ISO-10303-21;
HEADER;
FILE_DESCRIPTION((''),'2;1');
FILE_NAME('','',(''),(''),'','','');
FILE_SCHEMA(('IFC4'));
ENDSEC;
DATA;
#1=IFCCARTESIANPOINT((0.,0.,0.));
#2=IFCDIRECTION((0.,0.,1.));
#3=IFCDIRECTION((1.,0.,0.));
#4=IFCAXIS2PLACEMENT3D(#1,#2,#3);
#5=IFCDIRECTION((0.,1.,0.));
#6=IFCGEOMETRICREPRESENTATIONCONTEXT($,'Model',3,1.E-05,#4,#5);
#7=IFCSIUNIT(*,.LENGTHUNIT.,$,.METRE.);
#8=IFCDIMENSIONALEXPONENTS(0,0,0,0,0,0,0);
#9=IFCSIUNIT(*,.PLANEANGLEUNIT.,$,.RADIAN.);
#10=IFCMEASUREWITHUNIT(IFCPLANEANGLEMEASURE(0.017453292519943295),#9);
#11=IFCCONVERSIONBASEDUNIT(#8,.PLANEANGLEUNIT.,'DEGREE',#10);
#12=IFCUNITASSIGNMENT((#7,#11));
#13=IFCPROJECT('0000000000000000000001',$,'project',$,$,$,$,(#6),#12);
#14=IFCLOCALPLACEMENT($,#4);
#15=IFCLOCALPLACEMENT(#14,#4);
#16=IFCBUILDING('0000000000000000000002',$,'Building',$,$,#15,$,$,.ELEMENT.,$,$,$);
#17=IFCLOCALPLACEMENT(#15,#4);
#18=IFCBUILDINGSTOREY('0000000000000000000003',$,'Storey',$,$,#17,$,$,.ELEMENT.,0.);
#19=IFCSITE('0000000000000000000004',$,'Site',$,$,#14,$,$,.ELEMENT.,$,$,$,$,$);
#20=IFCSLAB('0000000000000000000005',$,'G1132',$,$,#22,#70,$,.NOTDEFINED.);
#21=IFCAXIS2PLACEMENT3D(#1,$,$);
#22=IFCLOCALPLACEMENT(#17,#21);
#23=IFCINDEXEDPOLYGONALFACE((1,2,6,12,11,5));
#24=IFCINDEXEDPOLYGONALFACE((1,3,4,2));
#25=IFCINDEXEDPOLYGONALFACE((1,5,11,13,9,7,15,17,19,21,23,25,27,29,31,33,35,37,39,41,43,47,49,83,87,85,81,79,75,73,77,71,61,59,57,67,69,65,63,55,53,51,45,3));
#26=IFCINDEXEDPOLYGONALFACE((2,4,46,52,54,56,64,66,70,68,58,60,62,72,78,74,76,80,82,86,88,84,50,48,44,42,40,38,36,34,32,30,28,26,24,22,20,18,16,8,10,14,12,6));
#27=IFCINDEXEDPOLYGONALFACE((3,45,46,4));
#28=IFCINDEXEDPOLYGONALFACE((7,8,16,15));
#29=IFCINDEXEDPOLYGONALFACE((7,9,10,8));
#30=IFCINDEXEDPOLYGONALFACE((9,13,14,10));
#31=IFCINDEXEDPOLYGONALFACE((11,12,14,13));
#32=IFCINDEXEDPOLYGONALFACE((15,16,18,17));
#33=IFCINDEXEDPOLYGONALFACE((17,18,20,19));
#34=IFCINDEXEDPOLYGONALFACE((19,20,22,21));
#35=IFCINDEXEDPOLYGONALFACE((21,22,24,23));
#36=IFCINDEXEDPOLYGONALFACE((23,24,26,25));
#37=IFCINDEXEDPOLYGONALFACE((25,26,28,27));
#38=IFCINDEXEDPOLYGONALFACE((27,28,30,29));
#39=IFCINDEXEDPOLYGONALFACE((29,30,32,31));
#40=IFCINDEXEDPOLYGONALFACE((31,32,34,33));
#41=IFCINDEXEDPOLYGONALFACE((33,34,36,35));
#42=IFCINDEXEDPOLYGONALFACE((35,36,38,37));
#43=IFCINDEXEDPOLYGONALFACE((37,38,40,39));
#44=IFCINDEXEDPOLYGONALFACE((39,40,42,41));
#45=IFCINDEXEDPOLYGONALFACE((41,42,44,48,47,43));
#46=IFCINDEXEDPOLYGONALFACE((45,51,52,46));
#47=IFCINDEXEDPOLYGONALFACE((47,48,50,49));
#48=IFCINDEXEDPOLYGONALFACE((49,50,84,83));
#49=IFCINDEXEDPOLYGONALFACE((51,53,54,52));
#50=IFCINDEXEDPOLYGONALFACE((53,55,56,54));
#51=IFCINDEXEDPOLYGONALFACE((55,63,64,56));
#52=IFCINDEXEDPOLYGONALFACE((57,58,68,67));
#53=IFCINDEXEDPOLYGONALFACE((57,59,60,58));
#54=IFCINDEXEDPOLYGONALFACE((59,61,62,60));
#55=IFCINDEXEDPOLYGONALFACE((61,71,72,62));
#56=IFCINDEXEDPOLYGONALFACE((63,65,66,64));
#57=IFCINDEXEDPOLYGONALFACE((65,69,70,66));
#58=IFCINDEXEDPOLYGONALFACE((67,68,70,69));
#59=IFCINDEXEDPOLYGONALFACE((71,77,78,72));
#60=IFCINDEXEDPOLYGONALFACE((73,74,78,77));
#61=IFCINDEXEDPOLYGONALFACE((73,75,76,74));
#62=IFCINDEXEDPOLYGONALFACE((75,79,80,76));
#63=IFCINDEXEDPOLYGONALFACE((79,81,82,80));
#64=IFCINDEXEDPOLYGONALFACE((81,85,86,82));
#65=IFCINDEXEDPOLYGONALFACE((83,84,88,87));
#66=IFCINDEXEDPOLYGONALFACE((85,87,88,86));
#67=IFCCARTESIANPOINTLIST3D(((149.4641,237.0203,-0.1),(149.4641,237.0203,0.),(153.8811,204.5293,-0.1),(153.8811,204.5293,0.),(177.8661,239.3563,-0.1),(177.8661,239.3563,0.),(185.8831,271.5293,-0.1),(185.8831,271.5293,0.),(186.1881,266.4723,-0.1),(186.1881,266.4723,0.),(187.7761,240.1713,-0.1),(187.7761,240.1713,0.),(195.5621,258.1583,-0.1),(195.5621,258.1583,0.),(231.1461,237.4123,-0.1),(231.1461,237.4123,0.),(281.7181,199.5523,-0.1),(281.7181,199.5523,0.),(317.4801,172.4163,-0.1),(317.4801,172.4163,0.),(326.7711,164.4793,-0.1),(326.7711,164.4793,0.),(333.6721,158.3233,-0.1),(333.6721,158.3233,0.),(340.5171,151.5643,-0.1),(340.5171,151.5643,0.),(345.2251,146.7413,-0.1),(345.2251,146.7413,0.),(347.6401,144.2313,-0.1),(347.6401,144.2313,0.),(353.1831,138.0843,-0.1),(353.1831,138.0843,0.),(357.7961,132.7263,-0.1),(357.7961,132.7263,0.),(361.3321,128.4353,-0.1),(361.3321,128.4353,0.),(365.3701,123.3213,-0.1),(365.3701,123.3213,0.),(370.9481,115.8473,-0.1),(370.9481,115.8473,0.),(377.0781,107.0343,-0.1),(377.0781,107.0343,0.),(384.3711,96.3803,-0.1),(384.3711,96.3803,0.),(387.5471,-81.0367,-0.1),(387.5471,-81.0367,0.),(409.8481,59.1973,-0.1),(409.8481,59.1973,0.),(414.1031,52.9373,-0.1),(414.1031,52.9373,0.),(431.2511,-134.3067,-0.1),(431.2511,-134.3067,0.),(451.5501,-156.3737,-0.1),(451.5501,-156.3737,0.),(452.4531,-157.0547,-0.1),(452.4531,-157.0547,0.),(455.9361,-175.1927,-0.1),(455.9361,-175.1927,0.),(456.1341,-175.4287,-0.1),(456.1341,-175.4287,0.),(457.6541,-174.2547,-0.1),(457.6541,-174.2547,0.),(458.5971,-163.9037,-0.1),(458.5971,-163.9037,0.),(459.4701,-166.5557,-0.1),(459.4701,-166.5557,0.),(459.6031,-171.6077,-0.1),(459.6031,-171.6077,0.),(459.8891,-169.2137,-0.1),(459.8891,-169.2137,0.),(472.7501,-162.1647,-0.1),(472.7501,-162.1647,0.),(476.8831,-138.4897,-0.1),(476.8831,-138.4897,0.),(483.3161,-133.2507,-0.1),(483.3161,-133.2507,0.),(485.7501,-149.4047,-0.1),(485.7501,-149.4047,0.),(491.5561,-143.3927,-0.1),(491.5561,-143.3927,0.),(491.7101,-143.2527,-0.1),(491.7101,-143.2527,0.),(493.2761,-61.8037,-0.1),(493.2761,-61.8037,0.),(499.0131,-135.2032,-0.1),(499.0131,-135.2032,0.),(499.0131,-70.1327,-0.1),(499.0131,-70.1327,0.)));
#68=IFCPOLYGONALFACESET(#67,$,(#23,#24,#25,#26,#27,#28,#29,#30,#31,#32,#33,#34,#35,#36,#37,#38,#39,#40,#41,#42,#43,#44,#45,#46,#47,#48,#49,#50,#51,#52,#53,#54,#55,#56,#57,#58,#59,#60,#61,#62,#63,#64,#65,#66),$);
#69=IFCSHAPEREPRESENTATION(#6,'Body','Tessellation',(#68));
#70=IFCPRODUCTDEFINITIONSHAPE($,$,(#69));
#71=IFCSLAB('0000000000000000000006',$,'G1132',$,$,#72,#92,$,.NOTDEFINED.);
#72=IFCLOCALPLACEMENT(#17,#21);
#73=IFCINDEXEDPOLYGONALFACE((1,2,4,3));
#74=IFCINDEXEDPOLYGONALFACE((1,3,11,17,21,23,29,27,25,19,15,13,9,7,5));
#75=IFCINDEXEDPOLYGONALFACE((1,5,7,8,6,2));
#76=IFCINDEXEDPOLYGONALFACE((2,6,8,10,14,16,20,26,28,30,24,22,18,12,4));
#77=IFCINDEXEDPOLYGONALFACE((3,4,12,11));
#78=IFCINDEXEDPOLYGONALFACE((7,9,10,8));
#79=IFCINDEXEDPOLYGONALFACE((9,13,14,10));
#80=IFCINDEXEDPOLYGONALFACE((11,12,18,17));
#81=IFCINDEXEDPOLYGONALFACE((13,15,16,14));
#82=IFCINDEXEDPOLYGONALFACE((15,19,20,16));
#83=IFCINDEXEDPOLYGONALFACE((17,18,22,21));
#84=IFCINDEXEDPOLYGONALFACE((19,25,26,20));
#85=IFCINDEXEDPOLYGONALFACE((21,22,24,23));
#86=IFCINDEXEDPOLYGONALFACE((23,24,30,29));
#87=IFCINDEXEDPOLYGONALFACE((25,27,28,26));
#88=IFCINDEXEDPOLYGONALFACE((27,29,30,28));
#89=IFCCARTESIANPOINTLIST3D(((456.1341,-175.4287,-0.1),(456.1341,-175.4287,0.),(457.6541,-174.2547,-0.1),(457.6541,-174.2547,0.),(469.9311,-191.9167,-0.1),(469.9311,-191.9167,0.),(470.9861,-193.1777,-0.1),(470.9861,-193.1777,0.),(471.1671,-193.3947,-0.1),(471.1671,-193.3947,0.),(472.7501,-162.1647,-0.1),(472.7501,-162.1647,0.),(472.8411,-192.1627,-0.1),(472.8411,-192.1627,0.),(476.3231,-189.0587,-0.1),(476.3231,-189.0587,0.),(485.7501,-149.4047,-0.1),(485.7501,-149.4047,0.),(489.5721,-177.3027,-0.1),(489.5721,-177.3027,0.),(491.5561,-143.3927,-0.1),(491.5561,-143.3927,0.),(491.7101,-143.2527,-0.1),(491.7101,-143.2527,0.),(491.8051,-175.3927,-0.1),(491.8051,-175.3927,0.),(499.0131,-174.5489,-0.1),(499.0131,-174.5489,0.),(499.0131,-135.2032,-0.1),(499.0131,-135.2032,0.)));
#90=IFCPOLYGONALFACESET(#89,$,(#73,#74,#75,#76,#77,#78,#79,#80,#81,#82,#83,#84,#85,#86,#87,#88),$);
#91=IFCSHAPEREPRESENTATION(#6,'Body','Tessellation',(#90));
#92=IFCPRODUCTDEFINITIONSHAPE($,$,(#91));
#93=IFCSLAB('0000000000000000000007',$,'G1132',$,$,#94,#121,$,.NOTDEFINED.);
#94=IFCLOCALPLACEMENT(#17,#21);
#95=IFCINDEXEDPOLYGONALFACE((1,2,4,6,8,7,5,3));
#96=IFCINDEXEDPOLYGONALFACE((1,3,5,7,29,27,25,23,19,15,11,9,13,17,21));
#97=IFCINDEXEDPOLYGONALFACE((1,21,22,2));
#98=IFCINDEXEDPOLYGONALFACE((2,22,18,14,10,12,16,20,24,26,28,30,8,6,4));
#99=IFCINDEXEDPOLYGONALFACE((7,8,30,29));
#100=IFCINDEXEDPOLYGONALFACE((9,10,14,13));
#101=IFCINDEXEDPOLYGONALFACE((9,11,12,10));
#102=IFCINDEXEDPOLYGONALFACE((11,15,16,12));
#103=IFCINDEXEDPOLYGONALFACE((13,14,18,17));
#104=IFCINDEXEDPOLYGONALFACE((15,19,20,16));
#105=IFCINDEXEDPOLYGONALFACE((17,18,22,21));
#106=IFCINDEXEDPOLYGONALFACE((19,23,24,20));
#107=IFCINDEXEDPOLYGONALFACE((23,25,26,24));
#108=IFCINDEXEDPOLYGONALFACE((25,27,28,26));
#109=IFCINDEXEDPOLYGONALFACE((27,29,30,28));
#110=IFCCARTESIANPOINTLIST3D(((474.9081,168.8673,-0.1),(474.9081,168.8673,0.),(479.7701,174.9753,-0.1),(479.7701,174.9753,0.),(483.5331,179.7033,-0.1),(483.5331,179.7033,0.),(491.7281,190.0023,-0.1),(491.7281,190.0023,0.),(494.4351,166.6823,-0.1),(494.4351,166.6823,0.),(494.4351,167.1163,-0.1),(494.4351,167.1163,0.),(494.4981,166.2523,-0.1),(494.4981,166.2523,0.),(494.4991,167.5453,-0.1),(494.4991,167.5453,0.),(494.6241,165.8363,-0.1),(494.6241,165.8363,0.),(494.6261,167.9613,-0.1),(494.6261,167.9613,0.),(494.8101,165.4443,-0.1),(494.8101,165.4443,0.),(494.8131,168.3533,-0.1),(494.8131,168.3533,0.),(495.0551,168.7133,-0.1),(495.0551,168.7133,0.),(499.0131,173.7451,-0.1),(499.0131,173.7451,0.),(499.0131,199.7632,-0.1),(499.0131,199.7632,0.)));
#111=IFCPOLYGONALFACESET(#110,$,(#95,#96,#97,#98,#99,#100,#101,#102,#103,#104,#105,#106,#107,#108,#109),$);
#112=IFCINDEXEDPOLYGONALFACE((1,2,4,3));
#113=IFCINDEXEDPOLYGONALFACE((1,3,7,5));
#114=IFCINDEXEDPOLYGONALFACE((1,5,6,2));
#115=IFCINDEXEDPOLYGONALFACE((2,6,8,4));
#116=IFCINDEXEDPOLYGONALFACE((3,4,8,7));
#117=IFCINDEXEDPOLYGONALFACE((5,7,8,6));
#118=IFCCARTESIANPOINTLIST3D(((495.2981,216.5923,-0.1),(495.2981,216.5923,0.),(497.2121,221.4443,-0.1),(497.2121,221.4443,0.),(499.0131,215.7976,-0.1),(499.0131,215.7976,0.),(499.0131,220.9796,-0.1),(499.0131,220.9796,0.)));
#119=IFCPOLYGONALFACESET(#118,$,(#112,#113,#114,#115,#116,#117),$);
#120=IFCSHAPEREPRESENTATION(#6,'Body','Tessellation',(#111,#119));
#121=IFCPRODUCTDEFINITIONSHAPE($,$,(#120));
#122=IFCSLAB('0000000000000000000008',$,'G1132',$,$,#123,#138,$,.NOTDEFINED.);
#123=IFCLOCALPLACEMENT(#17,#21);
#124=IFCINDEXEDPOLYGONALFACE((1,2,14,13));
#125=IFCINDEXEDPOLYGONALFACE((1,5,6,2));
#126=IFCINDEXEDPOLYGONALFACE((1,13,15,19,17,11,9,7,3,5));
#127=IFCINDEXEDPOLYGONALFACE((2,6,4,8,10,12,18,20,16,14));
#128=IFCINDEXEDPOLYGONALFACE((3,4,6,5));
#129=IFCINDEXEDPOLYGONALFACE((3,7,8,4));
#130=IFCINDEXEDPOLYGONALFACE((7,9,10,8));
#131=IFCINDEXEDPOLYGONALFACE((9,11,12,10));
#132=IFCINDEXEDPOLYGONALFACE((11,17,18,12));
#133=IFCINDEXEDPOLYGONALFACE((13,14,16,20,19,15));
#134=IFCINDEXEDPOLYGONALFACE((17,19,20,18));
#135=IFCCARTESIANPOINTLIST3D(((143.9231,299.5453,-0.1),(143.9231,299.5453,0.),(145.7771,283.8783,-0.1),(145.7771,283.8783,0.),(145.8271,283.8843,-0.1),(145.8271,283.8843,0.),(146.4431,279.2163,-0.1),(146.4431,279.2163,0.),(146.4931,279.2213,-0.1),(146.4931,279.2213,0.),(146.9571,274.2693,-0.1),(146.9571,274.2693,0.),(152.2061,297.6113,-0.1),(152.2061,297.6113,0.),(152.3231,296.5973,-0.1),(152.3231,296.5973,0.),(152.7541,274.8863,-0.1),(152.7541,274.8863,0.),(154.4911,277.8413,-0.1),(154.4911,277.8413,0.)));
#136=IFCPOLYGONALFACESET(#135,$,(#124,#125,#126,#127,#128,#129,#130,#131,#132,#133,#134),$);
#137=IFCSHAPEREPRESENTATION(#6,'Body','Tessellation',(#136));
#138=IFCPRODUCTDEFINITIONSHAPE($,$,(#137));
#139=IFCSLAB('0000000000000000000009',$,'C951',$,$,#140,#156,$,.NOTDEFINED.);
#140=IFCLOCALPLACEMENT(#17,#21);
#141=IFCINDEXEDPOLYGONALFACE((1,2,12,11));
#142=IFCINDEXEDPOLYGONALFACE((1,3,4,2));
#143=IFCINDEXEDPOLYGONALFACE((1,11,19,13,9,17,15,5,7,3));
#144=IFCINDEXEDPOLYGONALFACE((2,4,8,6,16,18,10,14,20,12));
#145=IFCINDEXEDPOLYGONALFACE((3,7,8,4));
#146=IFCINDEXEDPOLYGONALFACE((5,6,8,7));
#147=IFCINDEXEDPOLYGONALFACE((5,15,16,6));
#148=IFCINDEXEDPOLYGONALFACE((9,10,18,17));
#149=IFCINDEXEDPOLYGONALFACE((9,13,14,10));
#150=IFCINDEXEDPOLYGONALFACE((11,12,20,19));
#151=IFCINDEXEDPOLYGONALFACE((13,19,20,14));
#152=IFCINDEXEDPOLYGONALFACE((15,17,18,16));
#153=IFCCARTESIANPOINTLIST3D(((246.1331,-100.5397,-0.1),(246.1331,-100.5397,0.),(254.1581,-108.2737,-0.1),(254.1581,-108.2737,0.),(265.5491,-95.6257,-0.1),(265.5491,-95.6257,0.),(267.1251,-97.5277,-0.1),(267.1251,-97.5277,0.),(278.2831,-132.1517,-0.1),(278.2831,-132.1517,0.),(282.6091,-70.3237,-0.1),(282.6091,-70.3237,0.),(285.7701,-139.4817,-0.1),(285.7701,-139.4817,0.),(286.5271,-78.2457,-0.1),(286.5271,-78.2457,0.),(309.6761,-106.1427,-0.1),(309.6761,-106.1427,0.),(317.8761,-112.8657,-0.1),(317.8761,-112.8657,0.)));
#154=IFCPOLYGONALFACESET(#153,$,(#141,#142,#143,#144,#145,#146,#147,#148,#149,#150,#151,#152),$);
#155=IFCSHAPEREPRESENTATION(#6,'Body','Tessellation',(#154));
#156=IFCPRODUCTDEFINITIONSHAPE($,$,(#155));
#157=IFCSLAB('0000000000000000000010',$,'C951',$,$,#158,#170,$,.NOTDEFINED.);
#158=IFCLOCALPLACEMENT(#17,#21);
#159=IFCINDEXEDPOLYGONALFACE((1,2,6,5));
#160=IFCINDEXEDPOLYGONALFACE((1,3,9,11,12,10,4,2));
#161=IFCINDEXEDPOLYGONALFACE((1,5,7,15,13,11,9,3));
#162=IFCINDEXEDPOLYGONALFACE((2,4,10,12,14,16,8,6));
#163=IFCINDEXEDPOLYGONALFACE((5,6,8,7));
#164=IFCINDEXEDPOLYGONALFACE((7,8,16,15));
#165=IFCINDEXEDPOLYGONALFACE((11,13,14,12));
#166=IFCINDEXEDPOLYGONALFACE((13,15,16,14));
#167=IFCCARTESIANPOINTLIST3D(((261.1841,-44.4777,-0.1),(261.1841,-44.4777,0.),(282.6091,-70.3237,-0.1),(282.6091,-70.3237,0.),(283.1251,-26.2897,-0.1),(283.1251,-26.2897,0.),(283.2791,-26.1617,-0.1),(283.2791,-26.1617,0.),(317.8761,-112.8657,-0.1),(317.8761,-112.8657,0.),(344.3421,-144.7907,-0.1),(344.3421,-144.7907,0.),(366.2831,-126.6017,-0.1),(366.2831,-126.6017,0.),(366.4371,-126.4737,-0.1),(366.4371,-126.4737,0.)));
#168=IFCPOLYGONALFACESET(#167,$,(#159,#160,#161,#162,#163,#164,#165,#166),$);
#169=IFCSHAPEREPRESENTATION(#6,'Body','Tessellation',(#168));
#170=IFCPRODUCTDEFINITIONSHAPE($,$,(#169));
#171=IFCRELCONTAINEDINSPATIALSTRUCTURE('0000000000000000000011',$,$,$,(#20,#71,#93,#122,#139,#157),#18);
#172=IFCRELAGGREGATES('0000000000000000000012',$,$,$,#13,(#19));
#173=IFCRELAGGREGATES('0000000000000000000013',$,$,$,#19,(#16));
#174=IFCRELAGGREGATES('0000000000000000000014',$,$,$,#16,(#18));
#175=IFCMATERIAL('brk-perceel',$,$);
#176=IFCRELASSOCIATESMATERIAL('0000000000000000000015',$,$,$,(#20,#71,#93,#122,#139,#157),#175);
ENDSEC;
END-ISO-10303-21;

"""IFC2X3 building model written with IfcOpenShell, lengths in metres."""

from ifc_helpers import new_model, entity, si_unit, converted_unit, direction, frame, origin_with_axes, place, context, project, spatial, polyline, outline, extrude, material, element, save


model = new_model("IFC2X3")

# Units and contexts
model_context = context("Model", 3, precision=1e-05, world=origin_with_axes(), true_north=direction((0.0, 1.0, 0.0)))
ifc_project = project(units=[si_unit("LENGTHUNIT", "METRE"), converted_unit("PLANEANGLEUNIT", "DEGREE", entity("IfcPlaneAngleMeasure", 0.017453292519943295), si_unit("PLANEANGLEUNIT", "RADIAN"), dimensions=[0, 0, 0, 0, 0, 0, 0])], contexts=[model_context])

# Site, building, storey
site_placement = place(None, origin_with_axes())
site = spatial("IfcSite", under=ifc_project, at=site_placement, Name="Site", CompositionType="ELEMENT")
building_placement = place(site_placement, origin_with_axes())
building = spatial("IfcBuilding", under=site, at=building_placement, Name="Building", CompositionType="ELEMENT")
storey_placement = place(building_placement, origin_with_axes())
storey = spatial("IfcBuildingStorey", under=building, at=storey_placement, Name="Storey", CompositionType="ELEMENT", Elevation=0.0)

# Slabs
ifc_material = material(Name="brk-perceel")
slab_1_placement = place(storey_placement, frame((0.0, 0.0, -0.1), z_axis=(0.0, 0.0, 1.0), x_axis=(1.0, 0.0, 0.0)))
element("IfcSlab", 1, at=slab_1_placement, inside=storey, material=ifc_material, Name="G1132", PredefinedType="NOTDEFINED", context=model_context, shape_type="SweptSolid", body=[
    extrude(outline(polyline([(491.7101, -143.2527), (491.5561, -143.3927), (483.3161, -133.2507), (476.8831, -138.4897), (485.7501, -149.4047), (472.7501, -162.1647), (457.6541, -174.2547), (456.1341, -175.4287), (455.9361, -175.1927), (459.6031, -171.6077), (459.8891, -169.2137), (459.4701, -166.5557), (458.5971, -163.9037), (452.4531, -157.0547), (451.5501, -156.3737), (431.2511, -134.3067), (387.5471, -81.0367), (153.8811, 204.5293), (149.4641, 237.0203), (177.8661, 239.3563), (187.7761, 240.1713), (195.5621, 258.1583), (186.1881, 266.4723), (185.8831, 271.5293), (231.1461, 237.4123), (281.7181, 199.5523), (317.4801, 172.4163), (326.7711, 164.4793), (333.6721, 158.3233), (340.5171, 151.5643), (345.2251, 146.7413), (347.6401, 144.2313), (353.1831, 138.0843), (357.7961, 132.7263), (361.3321, 128.4353), (365.3701, 123.3213), (370.9481, 115.8473), (377.0781, 107.0343), (384.3711, 96.3803), (409.8481, 59.1973), (414.1031, 52.9373), (493.2761, -61.8037), (499.0131, -70.1327), (499.0131, -135.2032), (491.7101, -143.2527)])), origin_with_axes(), (0.0, 0.0, 1.0), 0.1),
])
slab_2_placement = place(storey_placement, frame((0.0, 0.0, -0.1), z_axis=(0.0, 0.0, 1.0), x_axis=(1.0, 0.0, 0.0)))
element("IfcSlab", 2, at=slab_2_placement, inside=storey, material=ifc_material, Name="G1132", PredefinedType="NOTDEFINED", context=model_context, shape_type="SweptSolid", body=[
    extrude(outline(polyline([(491.8051, -175.3927), (489.5721, -177.3027), (476.3231, -189.0587), (472.8411, -192.1627), (471.1671, -193.3947), (470.9861, -193.1777), (469.9311, -191.9167), (456.1341, -175.4287), (457.6541, -174.2547), (472.7501, -162.1647), (485.7501, -149.4047), (491.5561, -143.3927), (491.7101, -143.2527), (499.0131, -135.2032), (499.0131, -174.5489), (491.8051, -175.3927)])), origin_with_axes(), (0.0, 0.0, 1.0), 0.1),
])
slab_3_placement = place(storey_placement, frame((0.0, 0.0, -0.1), z_axis=(0.0, 0.0, 1.0), x_axis=(1.0, 0.0, 0.0)))
element("IfcSlab", 3, at=slab_3_placement, inside=storey, material=ifc_material, Name="G1132", PredefinedType="NOTDEFINED", context=model_context, shape_type="SweptSolid", body=[
    extrude(outline(polyline([(495.0551, 168.7133), (494.8131, 168.3533), (494.6261, 167.9613), (494.4991, 167.5453), (494.4351, 167.1163), (494.4351, 166.6823), (494.4981, 166.2523), (494.6241, 165.8363), (494.8101, 165.4443), (474.9081, 168.8673), (479.7701, 174.9753), (483.5331, 179.7033), (491.7281, 190.0023), (499.0131, 199.7632), (499.0131, 173.7451), (495.0551, 168.7133)])), origin_with_axes(), (0.0, 0.0, 1.0), 0.1),
    extrude(outline(polyline([(495.2981, 216.5923), (497.2121, 221.4443), (499.0131, 220.9796), (499.0131, 215.7976), (495.2981, 216.5923)])), origin_with_axes(), (0.0, 0.0, 1.0), 0.1),
])
slab_4_placement = place(storey_placement, frame((0.0, 0.0, -0.1), z_axis=(0.0, 0.0, 1.0), x_axis=(1.0, 0.0, 0.0)))
element("IfcSlab", 4, at=slab_4_placement, inside=storey, material=ifc_material, Name="G1132", PredefinedType="NOTDEFINED", context=model_context, shape_type="SweptSolid", body=[
    extrude(outline(polyline([(152.2061, 297.6113), (152.3231, 296.5973), (154.4911, 277.8413), (152.7541, 274.8863), (146.9571, 274.2693), (146.4931, 279.2213), (146.4431, 279.2163), (145.7771, 283.8783), (145.8271, 283.8843), (143.9231, 299.5453), (152.2061, 297.6113)])), origin_with_axes(), (0.0, 0.0, 1.0), 0.1),
])
slab_5_placement = place(storey_placement, frame((0.0, 0.0, -0.1), z_axis=(0.0, 0.0, 1.0), x_axis=(1.0, 0.0, 0.0)))
element("IfcSlab", 5, at=slab_5_placement, inside=storey, material=ifc_material, Name="C951", PredefinedType="NOTDEFINED", context=model_context, shape_type="SweptSolid", body=[
    extrude(outline(polyline([(317.8761, -112.8657), (285.7701, -139.4817), (278.2831, -132.1517), (309.6761, -106.1427), (286.5271, -78.2457), (265.5491, -95.6257), (267.1251, -97.5277), (254.1581, -108.2737), (246.1331, -100.5397), (282.6091, -70.3237), (317.8761, -112.8657)])), origin_with_axes(), (0.0, 0.0, 1.0), 0.1),
])
slab_6_placement = place(storey_placement, frame((0.0, 0.0, -0.1), z_axis=(0.0, 0.0, 1.0), x_axis=(1.0, 0.0, 0.0)))
element("IfcSlab", 6, at=slab_6_placement, inside=storey, material=ifc_material, Name="C951", PredefinedType="NOTDEFINED", context=model_context, shape_type="SweptSolid", body=[
    extrude(outline(polyline([(261.1841, -44.4777), (283.1251, -26.2897), (283.2791, -26.1617), (366.4371, -126.4737), (366.2831, -126.6017), (344.3421, -144.7907), (317.8761, -112.8657), (282.6091, -70.3237), (261.1841, -44.4777)])), origin_with_axes(), (0.0, 0.0, 1.0), 0.1),
])

save(model, "model.ifc")
